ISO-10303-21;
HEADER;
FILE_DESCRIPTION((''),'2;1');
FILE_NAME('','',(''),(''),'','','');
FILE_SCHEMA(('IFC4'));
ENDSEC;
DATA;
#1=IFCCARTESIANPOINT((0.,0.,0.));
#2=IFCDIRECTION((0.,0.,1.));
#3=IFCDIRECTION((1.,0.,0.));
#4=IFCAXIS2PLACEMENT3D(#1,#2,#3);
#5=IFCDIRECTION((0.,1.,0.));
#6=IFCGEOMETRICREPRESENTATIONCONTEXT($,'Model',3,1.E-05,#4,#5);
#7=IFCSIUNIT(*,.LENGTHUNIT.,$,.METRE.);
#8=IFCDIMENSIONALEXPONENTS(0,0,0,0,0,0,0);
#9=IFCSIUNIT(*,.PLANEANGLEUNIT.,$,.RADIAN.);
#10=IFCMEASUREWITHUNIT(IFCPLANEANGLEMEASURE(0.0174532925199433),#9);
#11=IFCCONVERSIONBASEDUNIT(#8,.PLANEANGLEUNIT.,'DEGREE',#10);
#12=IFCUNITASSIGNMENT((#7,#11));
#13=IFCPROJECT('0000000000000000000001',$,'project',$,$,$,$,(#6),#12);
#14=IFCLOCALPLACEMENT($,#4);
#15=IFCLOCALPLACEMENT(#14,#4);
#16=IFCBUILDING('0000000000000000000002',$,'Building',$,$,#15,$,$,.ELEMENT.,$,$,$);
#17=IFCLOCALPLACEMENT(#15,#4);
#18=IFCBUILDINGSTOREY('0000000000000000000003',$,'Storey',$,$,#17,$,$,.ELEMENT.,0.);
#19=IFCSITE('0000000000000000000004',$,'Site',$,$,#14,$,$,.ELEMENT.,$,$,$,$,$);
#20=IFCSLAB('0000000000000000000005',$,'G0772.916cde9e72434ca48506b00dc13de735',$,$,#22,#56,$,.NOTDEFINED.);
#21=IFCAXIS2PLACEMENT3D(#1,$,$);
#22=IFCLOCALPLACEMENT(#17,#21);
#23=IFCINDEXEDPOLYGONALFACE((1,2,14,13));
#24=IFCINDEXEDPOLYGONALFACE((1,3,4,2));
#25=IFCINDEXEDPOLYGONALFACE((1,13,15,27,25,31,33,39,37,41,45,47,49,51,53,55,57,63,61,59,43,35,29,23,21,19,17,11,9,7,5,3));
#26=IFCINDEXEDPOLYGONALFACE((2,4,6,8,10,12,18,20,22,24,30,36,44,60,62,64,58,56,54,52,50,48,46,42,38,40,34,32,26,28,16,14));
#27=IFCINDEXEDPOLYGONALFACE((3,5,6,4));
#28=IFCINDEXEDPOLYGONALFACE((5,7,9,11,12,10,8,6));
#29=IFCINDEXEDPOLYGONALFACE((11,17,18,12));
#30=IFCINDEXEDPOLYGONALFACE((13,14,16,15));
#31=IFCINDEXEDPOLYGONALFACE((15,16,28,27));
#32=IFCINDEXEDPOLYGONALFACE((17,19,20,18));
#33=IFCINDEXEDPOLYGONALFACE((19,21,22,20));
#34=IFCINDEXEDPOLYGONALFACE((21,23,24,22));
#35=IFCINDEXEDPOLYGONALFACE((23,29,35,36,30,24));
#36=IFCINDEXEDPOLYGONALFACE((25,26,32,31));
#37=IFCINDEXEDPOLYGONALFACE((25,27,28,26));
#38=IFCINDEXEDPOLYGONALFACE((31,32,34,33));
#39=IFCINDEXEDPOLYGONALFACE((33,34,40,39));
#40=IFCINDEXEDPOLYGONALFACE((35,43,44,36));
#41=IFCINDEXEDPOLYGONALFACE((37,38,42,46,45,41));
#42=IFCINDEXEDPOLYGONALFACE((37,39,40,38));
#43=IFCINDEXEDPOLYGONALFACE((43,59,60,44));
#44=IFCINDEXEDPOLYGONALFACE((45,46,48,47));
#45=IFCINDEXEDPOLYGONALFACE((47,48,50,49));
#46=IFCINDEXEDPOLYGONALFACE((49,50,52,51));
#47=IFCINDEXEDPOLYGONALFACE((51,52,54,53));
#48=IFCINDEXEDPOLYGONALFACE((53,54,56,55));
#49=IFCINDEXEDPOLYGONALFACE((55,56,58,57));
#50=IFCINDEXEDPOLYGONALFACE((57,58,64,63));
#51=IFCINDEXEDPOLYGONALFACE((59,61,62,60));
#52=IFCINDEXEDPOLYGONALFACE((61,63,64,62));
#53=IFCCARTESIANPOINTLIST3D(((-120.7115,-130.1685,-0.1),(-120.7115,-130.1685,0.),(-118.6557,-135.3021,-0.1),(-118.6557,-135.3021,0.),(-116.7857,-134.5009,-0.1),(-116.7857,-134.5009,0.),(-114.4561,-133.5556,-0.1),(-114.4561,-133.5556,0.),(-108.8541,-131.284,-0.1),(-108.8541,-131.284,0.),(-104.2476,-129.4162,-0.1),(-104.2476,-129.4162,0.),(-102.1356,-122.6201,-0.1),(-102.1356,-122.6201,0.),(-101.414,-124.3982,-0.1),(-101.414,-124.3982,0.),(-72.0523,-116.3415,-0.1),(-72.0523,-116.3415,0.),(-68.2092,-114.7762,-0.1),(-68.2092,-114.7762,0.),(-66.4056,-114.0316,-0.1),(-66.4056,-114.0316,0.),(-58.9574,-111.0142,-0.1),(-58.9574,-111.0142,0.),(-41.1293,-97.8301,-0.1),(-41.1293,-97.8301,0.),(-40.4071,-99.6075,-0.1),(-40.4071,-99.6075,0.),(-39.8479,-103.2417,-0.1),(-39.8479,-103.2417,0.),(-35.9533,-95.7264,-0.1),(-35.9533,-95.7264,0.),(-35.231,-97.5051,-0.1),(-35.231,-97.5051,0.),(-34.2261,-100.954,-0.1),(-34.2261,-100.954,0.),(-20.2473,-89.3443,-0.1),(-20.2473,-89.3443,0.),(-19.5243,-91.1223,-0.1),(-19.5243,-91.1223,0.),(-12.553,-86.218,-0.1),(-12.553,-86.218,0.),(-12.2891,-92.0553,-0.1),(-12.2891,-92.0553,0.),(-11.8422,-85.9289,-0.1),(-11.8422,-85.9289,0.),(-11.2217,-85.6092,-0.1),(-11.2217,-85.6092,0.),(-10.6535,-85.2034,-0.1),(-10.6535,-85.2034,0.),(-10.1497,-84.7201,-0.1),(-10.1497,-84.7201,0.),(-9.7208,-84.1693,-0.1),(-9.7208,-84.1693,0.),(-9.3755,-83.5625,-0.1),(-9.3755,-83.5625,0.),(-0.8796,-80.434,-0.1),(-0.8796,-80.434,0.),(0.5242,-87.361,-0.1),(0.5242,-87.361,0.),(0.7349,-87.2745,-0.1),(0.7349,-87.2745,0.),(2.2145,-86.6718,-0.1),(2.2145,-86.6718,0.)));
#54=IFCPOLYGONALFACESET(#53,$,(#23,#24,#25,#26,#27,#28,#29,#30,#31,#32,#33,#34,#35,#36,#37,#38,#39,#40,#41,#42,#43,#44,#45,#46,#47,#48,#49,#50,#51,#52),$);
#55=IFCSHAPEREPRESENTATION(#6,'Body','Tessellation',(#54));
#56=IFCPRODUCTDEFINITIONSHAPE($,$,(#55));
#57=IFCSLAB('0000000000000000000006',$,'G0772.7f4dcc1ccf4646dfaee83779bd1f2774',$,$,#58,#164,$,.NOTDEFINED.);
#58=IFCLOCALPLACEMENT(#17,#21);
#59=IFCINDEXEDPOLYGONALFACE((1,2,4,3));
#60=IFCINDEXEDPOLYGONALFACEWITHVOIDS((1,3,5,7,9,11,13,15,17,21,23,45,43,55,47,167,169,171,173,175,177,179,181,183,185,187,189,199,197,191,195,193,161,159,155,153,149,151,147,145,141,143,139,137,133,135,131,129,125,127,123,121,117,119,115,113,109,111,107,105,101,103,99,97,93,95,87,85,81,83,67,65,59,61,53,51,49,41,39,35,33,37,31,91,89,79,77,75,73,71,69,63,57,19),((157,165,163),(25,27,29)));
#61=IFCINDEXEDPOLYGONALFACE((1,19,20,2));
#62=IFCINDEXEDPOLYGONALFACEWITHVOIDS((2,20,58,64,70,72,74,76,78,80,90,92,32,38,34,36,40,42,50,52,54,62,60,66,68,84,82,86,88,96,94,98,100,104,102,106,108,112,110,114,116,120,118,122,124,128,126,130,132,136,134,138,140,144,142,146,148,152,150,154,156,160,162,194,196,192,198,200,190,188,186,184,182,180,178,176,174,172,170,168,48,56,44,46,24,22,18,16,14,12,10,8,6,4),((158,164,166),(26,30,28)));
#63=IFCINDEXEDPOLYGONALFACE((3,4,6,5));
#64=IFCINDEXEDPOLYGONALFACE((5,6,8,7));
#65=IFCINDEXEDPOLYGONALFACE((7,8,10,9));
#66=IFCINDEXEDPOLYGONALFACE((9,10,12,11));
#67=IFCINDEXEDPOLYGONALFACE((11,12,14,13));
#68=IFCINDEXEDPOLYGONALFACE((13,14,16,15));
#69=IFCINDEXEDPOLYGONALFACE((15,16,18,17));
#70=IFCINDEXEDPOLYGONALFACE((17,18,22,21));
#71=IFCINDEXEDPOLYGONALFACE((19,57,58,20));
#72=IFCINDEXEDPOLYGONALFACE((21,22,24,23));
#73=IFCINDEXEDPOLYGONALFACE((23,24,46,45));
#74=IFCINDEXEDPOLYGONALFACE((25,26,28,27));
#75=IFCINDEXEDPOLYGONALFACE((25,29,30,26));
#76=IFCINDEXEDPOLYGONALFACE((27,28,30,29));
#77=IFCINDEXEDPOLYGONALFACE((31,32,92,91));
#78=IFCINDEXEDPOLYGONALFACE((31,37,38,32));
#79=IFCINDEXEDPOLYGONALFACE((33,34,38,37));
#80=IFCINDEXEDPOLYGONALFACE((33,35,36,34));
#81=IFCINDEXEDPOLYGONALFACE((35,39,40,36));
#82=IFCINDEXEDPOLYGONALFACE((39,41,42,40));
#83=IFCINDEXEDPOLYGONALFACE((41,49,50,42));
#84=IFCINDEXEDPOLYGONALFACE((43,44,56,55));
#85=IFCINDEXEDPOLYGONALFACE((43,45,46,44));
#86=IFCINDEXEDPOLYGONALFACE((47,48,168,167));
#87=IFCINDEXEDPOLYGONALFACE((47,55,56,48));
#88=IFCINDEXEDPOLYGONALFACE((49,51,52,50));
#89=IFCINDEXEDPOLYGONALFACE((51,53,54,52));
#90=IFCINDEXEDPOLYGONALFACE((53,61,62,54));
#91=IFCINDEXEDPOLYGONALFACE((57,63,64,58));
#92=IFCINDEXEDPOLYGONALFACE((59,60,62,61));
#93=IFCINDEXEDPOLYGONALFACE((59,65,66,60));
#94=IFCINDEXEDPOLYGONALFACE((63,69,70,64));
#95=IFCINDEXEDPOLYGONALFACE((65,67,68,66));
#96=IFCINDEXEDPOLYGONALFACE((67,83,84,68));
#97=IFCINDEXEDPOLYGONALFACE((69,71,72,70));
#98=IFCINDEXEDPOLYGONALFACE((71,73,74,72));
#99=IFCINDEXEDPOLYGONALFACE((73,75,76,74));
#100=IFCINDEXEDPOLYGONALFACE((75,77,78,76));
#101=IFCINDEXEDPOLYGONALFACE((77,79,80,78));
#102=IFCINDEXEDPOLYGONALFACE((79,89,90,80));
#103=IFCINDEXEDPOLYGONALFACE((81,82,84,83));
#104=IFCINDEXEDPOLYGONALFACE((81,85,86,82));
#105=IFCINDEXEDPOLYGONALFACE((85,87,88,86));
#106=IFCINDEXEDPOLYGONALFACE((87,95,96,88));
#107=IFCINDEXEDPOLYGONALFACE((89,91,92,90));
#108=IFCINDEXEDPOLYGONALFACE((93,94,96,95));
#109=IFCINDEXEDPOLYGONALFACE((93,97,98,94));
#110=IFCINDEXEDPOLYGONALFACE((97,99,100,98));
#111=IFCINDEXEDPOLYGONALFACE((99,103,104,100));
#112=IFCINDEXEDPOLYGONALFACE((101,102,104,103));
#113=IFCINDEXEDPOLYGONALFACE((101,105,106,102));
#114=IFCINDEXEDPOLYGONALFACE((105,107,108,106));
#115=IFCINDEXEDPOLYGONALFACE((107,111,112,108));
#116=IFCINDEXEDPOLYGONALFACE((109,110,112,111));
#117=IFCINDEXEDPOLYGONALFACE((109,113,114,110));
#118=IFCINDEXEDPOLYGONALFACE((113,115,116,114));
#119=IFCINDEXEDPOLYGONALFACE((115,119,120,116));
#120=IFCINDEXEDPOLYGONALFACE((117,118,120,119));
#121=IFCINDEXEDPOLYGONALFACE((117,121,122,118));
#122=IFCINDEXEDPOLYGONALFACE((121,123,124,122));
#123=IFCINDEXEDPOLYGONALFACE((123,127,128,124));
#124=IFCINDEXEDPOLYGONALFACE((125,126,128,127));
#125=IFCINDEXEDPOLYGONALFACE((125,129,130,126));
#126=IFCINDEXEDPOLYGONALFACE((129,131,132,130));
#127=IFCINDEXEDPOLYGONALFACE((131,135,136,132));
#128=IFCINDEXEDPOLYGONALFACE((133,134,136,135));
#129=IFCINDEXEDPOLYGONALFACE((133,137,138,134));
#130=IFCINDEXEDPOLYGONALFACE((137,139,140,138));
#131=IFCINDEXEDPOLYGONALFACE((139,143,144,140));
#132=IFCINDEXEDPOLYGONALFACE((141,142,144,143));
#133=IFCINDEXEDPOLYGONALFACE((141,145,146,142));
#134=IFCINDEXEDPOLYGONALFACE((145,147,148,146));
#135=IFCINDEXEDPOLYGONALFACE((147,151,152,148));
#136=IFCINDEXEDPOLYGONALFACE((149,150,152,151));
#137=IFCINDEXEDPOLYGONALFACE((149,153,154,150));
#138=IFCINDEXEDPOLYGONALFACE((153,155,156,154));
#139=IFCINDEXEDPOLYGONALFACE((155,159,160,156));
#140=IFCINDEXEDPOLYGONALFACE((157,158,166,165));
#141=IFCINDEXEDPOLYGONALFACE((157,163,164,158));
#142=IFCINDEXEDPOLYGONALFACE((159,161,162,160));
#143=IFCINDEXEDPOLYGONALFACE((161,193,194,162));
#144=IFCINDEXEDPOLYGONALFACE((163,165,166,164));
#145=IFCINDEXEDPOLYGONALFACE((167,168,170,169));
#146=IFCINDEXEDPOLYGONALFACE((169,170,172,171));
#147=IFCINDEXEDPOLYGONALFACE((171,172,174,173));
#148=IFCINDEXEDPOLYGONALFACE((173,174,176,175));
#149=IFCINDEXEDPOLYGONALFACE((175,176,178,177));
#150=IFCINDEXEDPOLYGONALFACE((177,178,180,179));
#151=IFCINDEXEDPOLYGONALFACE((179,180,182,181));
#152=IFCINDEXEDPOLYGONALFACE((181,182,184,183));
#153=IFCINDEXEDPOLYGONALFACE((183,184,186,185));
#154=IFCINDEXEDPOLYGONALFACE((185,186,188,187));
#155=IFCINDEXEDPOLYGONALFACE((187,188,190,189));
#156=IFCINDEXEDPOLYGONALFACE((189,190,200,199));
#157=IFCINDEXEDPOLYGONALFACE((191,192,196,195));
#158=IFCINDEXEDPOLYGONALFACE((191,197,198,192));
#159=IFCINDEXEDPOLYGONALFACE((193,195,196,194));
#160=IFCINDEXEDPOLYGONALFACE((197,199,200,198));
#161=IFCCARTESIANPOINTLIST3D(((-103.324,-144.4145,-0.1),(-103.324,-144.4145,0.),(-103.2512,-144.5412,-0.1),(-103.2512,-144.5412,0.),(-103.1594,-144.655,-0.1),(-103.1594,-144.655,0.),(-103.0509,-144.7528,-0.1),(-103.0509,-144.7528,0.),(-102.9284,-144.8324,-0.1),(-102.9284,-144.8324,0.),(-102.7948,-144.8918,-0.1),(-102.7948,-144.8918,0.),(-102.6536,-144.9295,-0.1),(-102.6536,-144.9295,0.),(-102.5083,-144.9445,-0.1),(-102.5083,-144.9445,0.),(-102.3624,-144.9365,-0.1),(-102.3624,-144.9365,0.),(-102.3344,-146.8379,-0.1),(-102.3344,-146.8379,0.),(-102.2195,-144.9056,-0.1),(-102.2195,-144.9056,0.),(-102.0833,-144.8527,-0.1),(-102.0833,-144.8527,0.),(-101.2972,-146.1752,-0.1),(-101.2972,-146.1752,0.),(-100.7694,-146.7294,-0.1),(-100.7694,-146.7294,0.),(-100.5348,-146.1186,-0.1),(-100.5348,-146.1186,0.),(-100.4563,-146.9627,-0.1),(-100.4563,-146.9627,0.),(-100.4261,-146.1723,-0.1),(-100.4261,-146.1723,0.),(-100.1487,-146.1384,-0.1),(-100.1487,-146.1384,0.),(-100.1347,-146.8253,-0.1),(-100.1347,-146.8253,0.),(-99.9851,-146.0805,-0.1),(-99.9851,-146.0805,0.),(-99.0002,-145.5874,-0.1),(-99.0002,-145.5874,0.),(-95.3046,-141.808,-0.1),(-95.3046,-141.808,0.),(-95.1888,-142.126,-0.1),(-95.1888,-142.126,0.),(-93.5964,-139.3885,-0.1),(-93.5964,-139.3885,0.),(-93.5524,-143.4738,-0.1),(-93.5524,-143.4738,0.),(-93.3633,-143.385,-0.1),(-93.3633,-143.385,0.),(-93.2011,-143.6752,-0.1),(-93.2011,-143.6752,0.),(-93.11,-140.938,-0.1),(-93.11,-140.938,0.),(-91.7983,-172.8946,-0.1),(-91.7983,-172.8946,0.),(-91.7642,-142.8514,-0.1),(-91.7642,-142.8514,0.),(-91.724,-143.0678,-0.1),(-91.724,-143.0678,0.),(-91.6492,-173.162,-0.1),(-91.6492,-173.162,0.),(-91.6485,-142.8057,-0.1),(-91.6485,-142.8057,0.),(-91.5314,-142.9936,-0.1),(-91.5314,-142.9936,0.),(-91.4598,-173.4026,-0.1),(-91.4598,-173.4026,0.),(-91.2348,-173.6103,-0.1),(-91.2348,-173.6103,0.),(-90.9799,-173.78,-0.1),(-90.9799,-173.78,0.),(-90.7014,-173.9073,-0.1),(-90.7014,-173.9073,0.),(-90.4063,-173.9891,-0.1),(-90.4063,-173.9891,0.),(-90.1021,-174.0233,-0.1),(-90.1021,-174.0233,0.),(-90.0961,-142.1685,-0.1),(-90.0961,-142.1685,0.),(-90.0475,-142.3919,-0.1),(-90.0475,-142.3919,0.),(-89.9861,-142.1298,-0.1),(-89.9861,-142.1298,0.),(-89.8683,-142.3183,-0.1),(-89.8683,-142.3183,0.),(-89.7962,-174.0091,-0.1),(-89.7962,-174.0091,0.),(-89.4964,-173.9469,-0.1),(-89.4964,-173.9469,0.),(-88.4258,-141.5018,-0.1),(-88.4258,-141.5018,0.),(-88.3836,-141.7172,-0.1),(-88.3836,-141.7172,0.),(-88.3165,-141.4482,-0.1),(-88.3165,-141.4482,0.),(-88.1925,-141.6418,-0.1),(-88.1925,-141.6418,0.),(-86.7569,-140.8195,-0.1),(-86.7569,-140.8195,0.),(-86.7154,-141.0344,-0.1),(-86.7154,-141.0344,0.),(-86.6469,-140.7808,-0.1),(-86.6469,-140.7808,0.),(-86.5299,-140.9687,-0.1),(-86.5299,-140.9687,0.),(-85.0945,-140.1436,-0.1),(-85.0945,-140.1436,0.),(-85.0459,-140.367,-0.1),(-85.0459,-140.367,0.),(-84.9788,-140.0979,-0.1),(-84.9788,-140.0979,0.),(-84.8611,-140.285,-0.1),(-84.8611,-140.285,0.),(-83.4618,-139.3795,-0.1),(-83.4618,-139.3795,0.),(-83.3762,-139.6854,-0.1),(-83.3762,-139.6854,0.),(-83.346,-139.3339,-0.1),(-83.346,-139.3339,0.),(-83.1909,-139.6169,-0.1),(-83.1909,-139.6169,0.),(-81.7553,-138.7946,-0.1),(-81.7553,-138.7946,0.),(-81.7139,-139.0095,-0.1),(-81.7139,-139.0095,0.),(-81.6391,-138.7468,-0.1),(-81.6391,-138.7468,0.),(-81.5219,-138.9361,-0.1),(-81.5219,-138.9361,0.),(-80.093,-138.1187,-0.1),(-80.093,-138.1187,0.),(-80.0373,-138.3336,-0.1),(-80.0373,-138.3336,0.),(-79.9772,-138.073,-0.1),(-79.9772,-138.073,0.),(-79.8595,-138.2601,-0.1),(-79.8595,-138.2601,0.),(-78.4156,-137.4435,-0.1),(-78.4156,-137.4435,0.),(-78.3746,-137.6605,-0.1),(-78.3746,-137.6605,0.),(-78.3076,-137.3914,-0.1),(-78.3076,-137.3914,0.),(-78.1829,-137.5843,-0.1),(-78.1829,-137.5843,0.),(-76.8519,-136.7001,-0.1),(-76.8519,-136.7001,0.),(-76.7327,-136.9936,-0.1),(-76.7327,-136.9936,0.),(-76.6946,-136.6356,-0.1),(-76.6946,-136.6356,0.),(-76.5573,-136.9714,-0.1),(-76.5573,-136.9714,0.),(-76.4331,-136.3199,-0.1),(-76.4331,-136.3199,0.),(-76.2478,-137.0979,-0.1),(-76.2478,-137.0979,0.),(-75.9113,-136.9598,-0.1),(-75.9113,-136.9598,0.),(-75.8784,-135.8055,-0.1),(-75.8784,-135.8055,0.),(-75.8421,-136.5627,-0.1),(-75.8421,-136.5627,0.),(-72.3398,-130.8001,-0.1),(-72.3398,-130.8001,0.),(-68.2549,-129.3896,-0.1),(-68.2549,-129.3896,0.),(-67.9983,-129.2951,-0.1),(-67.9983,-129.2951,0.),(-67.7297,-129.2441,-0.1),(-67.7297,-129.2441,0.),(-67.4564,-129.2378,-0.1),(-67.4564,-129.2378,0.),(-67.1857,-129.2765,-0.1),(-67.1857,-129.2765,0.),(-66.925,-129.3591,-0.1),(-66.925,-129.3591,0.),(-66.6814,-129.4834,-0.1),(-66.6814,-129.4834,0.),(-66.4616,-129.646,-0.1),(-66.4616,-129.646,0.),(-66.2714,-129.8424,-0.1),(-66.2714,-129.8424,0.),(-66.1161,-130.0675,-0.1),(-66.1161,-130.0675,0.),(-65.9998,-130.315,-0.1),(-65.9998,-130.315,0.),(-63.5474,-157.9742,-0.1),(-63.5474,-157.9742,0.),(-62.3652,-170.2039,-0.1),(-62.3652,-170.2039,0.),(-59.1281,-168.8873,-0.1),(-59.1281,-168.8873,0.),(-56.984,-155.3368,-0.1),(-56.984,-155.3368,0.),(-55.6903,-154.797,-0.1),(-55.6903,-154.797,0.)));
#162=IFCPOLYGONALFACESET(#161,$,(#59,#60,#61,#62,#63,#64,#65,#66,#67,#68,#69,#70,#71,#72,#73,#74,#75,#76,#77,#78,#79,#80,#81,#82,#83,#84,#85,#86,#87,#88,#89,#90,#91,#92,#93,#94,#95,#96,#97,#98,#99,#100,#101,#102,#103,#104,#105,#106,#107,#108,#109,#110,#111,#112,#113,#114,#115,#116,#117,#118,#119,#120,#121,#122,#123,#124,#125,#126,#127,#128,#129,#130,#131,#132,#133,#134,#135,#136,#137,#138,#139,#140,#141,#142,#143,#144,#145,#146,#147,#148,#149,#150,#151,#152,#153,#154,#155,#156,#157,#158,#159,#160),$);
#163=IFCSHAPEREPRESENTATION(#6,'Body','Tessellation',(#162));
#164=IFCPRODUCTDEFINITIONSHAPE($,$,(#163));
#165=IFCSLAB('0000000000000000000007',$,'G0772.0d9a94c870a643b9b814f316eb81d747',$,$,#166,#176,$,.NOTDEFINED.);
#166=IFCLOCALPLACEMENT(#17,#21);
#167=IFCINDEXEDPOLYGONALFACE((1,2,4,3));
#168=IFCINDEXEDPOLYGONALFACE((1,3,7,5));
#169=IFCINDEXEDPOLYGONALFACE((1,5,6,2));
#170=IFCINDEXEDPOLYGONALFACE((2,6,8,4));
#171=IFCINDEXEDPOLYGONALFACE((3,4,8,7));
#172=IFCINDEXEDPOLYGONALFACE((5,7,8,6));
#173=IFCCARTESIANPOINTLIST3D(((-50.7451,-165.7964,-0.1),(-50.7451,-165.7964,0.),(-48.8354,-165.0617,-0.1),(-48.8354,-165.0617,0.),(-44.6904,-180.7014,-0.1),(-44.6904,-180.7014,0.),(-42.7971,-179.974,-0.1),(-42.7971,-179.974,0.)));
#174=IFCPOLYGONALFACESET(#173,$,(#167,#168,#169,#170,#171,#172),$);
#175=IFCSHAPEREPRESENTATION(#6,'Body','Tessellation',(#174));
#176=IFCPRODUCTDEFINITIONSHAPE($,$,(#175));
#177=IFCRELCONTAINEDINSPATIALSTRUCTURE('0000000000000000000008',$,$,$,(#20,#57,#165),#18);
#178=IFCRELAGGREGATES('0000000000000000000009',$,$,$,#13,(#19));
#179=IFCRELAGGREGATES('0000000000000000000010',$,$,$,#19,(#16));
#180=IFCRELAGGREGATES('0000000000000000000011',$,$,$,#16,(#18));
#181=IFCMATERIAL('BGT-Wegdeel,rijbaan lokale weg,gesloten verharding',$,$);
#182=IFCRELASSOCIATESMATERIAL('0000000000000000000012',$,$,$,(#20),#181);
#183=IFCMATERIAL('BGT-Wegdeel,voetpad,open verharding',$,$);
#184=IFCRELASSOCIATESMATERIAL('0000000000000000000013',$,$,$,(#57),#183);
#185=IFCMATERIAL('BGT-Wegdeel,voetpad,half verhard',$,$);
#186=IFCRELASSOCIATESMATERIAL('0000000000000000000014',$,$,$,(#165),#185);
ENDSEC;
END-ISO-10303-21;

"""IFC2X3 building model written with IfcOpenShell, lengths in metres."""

from ifc_helpers import new_model, entity, si_unit, converted_unit, direction, frame, origin_with_axes, place, context, project, spatial, polyline, outline, extrude, material, element, save


model = new_model("IFC2X3")

# Units and contexts
model_context = context("Model", 3, precision=1e-05, world=origin_with_axes(), true_north=direction((0.0, 1.0, 0.0)))
ifc_project = project(units=[si_unit("LENGTHUNIT", "METRE"), converted_unit("PLANEANGLEUNIT", "DEGREE", entity("IfcPlaneAngleMeasure", 0.0174532925199433), si_unit("PLANEANGLEUNIT", "RADIAN"), dimensions=[0, 0, 0, 0, 0, 0, 0])], contexts=[model_context])

# Site, building, storey
site_placement = place(None, origin_with_axes())
site = spatial("IfcSite", under=ifc_project, at=site_placement, Name="Site", CompositionType="ELEMENT")
building_placement = place(site_placement, origin_with_axes())
building = spatial("IfcBuilding", under=site, at=building_placement, Name="Building", CompositionType="ELEMENT")
storey_placement = place(building_placement, origin_with_axes())
storey = spatial("IfcBuildingStorey", under=building, at=storey_placement, Name="Storey", CompositionType="ELEMENT", Elevation=0.0)

# Slabs
ifc_material_1 = material(Name="BGT-Wegdeel,voetpad,open verharding")
ifc_material_2 = material(Name="BGT-Wegdeel,rijbaan lokale weg,gesloten verharding")
slab_1_placement = place(storey_placement, frame((0.0, 0.0, -0.1), z_axis=(0.0, 0.0, 1.0), x_axis=(1.0, 0.0, 0.0)))
element("IfcSlab", 1, at=slab_1_placement, inside=storey, material=ifc_material_2, Name="G0772.916cde9e72434ca48506b00dc13de735", PredefinedType="NOTDEFINED", context=model_context, shape_type="SweptSolid", body=[
    extrude(outline(polyline([(-0.8796, -80.434), (2.2145, -86.6718), (0.7349, -87.2745), (0.5242, -87.361), (-12.2891, -92.0553), (-34.2261, -100.954), (-39.8479, -103.2417), (-58.9574, -111.0142), (-66.4056, -114.0316), (-68.2092, -114.7762), (-72.0523, -116.3415), (-104.2476, -129.4162), (-108.8541, -131.284), (-114.4561, -133.5556), (-116.7857, -134.5009), (-118.6557, -135.3021), (-120.7115, -130.1685), (-102.1356, -122.6201), (-101.414, -124.3982), (-40.4071, -99.6075), (-41.1293, -97.8301), (-35.9533, -95.7264), (-35.231, -97.5051), (-19.5243, -91.1223), (-20.2473, -89.3443), (-12.553, -86.218), (-11.8422, -85.9289), (-11.2217, -85.6092), (-10.6535, -85.2034), (-10.1497, -84.7201), (-9.7208, -84.1693), (-9.3755, -83.5625), (-0.8796, -80.434)])), origin_with_axes(), (0.0, 0.0, 1.0), 0.1),
])
slab_2_placement = place(storey_placement, frame((0.0, 0.0, -0.1), z_axis=(0.0, 0.0, 1.0), x_axis=(1.0, 0.0, 0.0)))
element("IfcSlab", 2, at=slab_2_placement, inside=storey, material=ifc_material_1, Name="G0772.7f4dcc1ccf4646dfaee83779bd1f2774", PredefinedType="NOTDEFINED", context=model_context, shape_type="SweptSolid", body=[
    extrude(outline(polyline([(-55.6903, -154.797), (-56.984, -155.3368), (-63.5474, -157.9742), (-59.1281, -168.8873), (-62.3652, -170.2039), (-75.9113, -136.9598), (-76.2478, -137.0979), (-76.5573, -136.9714), (-76.6946, -136.6356), (-76.8519, -136.7001), (-76.7327, -136.9936), (-78.1829, -137.5843), (-78.3076, -137.3914), (-78.4156, -137.4435), (-78.3746, -137.6605), (-79.8595, -138.2601), (-79.9772, -138.073), (-80.093, -138.1187), (-80.0373, -138.3336), (-81.5219, -138.9361), (-81.6391, -138.7468), (-81.7553, -138.7946), (-81.7139, -139.0095), (-83.1909, -139.6169), (-83.346, -139.3339), (-83.4618, -139.3795), (-83.3762, -139.6854), (-84.8611, -140.285), (-84.9788, -140.0979), (-85.0945, -140.1436), (-85.0459, -140.367), (-86.5299, -140.9687), (-86.6469, -140.7808), (-86.7569, -140.8195), (-86.7154, -141.0344), (-88.1925, -141.6418), (-88.3165, -141.4482), (-88.4258, -141.5018), (-88.3836, -141.7172), (-89.8683, -142.3183), (-89.9861, -142.1298), (-90.0961, -142.1685), (-90.0475, -142.3919), (-91.5314, -142.9936), (-91.6485, -142.8057), (-91.7642, -142.8514), (-91.724, -143.0678), (-93.2011, -143.6752), (-93.3633, -143.385), (-93.5524, -143.4738), (-99.0002, -145.5874), (-99.9851, -146.0805), (-100.1487, -146.1384), (-100.4261, -146.1723), (-100.1347, -146.8253), (-100.4563, -146.9627), (-89.4964, -173.9469), (-89.7962, -174.0091), (-90.1021, -174.0233), (-90.4063, -173.9891), (-90.7014, -173.9073), (-90.9799, -173.78), (-91.2348, -173.6103), (-91.4598, -173.4026), (-91.6492, -173.162), (-91.7983, -172.8946), (-102.3344, -146.8379), (-103.324, -144.4145), (-103.2512, -144.5412), (-103.1594, -144.655), (-103.0509, -144.7528), (-102.9284, -144.8324), (-102.7948, -144.8918), (-102.6536, -144.9295), (-102.5083, -144.9445), (-102.3624, -144.9365), (-102.2195, -144.9056), (-102.0833, -144.8527), (-95.1888, -142.126), (-95.3046, -141.808), (-93.11, -140.938), (-93.5964, -139.3885), (-72.3398, -130.8001), (-68.2549, -129.3896), (-67.9983, -129.2951), (-67.7297, -129.2441), (-67.4564, -129.2378), (-67.1857, -129.2765), (-66.925, -129.3591), (-66.6814, -129.4834), (-66.4616, -129.646), (-66.2714, -129.8424), (-66.1161, -130.0675), (-65.9998, -130.315), (-55.6903, -154.797)]), holes=[polyline([(-100.5348, -146.1186), (-101.2972, -146.1752), (-100.7694, -146.7294), (-100.5348, -146.1186)]), polyline([(-75.8784, -135.8055), (-76.4331, -136.3199), (-75.8421, -136.5627), (-75.8784, -135.8055)])]), origin_with_axes(), (0.0, 0.0, 1.0), 0.1),
])
ifc_material_3 = material(Name="BGT-Wegdeel,voetpad,half verhard")
slab_3_placement = place(storey_placement, frame((0.0, 0.0, -0.1), z_axis=(0.0, 0.0, 1.0), x_axis=(1.0, 0.0, 0.0)))
element("IfcSlab", 3, at=slab_3_placement, inside=storey, material=ifc_material_3, Name="G0772.0d9a94c870a643b9b814f316eb81d747", PredefinedType="NOTDEFINED", context=model_context, shape_type="SweptSolid", body=[
    extrude(outline(polyline([(-42.7971, -179.974), (-44.6904, -180.7014), (-50.7451, -165.7964), (-48.8354, -165.0617), (-42.7971, -179.974)])), origin_with_axes(), (0.0, 0.0, 1.0), 0.1),
])

save(model, "model.ifc")
